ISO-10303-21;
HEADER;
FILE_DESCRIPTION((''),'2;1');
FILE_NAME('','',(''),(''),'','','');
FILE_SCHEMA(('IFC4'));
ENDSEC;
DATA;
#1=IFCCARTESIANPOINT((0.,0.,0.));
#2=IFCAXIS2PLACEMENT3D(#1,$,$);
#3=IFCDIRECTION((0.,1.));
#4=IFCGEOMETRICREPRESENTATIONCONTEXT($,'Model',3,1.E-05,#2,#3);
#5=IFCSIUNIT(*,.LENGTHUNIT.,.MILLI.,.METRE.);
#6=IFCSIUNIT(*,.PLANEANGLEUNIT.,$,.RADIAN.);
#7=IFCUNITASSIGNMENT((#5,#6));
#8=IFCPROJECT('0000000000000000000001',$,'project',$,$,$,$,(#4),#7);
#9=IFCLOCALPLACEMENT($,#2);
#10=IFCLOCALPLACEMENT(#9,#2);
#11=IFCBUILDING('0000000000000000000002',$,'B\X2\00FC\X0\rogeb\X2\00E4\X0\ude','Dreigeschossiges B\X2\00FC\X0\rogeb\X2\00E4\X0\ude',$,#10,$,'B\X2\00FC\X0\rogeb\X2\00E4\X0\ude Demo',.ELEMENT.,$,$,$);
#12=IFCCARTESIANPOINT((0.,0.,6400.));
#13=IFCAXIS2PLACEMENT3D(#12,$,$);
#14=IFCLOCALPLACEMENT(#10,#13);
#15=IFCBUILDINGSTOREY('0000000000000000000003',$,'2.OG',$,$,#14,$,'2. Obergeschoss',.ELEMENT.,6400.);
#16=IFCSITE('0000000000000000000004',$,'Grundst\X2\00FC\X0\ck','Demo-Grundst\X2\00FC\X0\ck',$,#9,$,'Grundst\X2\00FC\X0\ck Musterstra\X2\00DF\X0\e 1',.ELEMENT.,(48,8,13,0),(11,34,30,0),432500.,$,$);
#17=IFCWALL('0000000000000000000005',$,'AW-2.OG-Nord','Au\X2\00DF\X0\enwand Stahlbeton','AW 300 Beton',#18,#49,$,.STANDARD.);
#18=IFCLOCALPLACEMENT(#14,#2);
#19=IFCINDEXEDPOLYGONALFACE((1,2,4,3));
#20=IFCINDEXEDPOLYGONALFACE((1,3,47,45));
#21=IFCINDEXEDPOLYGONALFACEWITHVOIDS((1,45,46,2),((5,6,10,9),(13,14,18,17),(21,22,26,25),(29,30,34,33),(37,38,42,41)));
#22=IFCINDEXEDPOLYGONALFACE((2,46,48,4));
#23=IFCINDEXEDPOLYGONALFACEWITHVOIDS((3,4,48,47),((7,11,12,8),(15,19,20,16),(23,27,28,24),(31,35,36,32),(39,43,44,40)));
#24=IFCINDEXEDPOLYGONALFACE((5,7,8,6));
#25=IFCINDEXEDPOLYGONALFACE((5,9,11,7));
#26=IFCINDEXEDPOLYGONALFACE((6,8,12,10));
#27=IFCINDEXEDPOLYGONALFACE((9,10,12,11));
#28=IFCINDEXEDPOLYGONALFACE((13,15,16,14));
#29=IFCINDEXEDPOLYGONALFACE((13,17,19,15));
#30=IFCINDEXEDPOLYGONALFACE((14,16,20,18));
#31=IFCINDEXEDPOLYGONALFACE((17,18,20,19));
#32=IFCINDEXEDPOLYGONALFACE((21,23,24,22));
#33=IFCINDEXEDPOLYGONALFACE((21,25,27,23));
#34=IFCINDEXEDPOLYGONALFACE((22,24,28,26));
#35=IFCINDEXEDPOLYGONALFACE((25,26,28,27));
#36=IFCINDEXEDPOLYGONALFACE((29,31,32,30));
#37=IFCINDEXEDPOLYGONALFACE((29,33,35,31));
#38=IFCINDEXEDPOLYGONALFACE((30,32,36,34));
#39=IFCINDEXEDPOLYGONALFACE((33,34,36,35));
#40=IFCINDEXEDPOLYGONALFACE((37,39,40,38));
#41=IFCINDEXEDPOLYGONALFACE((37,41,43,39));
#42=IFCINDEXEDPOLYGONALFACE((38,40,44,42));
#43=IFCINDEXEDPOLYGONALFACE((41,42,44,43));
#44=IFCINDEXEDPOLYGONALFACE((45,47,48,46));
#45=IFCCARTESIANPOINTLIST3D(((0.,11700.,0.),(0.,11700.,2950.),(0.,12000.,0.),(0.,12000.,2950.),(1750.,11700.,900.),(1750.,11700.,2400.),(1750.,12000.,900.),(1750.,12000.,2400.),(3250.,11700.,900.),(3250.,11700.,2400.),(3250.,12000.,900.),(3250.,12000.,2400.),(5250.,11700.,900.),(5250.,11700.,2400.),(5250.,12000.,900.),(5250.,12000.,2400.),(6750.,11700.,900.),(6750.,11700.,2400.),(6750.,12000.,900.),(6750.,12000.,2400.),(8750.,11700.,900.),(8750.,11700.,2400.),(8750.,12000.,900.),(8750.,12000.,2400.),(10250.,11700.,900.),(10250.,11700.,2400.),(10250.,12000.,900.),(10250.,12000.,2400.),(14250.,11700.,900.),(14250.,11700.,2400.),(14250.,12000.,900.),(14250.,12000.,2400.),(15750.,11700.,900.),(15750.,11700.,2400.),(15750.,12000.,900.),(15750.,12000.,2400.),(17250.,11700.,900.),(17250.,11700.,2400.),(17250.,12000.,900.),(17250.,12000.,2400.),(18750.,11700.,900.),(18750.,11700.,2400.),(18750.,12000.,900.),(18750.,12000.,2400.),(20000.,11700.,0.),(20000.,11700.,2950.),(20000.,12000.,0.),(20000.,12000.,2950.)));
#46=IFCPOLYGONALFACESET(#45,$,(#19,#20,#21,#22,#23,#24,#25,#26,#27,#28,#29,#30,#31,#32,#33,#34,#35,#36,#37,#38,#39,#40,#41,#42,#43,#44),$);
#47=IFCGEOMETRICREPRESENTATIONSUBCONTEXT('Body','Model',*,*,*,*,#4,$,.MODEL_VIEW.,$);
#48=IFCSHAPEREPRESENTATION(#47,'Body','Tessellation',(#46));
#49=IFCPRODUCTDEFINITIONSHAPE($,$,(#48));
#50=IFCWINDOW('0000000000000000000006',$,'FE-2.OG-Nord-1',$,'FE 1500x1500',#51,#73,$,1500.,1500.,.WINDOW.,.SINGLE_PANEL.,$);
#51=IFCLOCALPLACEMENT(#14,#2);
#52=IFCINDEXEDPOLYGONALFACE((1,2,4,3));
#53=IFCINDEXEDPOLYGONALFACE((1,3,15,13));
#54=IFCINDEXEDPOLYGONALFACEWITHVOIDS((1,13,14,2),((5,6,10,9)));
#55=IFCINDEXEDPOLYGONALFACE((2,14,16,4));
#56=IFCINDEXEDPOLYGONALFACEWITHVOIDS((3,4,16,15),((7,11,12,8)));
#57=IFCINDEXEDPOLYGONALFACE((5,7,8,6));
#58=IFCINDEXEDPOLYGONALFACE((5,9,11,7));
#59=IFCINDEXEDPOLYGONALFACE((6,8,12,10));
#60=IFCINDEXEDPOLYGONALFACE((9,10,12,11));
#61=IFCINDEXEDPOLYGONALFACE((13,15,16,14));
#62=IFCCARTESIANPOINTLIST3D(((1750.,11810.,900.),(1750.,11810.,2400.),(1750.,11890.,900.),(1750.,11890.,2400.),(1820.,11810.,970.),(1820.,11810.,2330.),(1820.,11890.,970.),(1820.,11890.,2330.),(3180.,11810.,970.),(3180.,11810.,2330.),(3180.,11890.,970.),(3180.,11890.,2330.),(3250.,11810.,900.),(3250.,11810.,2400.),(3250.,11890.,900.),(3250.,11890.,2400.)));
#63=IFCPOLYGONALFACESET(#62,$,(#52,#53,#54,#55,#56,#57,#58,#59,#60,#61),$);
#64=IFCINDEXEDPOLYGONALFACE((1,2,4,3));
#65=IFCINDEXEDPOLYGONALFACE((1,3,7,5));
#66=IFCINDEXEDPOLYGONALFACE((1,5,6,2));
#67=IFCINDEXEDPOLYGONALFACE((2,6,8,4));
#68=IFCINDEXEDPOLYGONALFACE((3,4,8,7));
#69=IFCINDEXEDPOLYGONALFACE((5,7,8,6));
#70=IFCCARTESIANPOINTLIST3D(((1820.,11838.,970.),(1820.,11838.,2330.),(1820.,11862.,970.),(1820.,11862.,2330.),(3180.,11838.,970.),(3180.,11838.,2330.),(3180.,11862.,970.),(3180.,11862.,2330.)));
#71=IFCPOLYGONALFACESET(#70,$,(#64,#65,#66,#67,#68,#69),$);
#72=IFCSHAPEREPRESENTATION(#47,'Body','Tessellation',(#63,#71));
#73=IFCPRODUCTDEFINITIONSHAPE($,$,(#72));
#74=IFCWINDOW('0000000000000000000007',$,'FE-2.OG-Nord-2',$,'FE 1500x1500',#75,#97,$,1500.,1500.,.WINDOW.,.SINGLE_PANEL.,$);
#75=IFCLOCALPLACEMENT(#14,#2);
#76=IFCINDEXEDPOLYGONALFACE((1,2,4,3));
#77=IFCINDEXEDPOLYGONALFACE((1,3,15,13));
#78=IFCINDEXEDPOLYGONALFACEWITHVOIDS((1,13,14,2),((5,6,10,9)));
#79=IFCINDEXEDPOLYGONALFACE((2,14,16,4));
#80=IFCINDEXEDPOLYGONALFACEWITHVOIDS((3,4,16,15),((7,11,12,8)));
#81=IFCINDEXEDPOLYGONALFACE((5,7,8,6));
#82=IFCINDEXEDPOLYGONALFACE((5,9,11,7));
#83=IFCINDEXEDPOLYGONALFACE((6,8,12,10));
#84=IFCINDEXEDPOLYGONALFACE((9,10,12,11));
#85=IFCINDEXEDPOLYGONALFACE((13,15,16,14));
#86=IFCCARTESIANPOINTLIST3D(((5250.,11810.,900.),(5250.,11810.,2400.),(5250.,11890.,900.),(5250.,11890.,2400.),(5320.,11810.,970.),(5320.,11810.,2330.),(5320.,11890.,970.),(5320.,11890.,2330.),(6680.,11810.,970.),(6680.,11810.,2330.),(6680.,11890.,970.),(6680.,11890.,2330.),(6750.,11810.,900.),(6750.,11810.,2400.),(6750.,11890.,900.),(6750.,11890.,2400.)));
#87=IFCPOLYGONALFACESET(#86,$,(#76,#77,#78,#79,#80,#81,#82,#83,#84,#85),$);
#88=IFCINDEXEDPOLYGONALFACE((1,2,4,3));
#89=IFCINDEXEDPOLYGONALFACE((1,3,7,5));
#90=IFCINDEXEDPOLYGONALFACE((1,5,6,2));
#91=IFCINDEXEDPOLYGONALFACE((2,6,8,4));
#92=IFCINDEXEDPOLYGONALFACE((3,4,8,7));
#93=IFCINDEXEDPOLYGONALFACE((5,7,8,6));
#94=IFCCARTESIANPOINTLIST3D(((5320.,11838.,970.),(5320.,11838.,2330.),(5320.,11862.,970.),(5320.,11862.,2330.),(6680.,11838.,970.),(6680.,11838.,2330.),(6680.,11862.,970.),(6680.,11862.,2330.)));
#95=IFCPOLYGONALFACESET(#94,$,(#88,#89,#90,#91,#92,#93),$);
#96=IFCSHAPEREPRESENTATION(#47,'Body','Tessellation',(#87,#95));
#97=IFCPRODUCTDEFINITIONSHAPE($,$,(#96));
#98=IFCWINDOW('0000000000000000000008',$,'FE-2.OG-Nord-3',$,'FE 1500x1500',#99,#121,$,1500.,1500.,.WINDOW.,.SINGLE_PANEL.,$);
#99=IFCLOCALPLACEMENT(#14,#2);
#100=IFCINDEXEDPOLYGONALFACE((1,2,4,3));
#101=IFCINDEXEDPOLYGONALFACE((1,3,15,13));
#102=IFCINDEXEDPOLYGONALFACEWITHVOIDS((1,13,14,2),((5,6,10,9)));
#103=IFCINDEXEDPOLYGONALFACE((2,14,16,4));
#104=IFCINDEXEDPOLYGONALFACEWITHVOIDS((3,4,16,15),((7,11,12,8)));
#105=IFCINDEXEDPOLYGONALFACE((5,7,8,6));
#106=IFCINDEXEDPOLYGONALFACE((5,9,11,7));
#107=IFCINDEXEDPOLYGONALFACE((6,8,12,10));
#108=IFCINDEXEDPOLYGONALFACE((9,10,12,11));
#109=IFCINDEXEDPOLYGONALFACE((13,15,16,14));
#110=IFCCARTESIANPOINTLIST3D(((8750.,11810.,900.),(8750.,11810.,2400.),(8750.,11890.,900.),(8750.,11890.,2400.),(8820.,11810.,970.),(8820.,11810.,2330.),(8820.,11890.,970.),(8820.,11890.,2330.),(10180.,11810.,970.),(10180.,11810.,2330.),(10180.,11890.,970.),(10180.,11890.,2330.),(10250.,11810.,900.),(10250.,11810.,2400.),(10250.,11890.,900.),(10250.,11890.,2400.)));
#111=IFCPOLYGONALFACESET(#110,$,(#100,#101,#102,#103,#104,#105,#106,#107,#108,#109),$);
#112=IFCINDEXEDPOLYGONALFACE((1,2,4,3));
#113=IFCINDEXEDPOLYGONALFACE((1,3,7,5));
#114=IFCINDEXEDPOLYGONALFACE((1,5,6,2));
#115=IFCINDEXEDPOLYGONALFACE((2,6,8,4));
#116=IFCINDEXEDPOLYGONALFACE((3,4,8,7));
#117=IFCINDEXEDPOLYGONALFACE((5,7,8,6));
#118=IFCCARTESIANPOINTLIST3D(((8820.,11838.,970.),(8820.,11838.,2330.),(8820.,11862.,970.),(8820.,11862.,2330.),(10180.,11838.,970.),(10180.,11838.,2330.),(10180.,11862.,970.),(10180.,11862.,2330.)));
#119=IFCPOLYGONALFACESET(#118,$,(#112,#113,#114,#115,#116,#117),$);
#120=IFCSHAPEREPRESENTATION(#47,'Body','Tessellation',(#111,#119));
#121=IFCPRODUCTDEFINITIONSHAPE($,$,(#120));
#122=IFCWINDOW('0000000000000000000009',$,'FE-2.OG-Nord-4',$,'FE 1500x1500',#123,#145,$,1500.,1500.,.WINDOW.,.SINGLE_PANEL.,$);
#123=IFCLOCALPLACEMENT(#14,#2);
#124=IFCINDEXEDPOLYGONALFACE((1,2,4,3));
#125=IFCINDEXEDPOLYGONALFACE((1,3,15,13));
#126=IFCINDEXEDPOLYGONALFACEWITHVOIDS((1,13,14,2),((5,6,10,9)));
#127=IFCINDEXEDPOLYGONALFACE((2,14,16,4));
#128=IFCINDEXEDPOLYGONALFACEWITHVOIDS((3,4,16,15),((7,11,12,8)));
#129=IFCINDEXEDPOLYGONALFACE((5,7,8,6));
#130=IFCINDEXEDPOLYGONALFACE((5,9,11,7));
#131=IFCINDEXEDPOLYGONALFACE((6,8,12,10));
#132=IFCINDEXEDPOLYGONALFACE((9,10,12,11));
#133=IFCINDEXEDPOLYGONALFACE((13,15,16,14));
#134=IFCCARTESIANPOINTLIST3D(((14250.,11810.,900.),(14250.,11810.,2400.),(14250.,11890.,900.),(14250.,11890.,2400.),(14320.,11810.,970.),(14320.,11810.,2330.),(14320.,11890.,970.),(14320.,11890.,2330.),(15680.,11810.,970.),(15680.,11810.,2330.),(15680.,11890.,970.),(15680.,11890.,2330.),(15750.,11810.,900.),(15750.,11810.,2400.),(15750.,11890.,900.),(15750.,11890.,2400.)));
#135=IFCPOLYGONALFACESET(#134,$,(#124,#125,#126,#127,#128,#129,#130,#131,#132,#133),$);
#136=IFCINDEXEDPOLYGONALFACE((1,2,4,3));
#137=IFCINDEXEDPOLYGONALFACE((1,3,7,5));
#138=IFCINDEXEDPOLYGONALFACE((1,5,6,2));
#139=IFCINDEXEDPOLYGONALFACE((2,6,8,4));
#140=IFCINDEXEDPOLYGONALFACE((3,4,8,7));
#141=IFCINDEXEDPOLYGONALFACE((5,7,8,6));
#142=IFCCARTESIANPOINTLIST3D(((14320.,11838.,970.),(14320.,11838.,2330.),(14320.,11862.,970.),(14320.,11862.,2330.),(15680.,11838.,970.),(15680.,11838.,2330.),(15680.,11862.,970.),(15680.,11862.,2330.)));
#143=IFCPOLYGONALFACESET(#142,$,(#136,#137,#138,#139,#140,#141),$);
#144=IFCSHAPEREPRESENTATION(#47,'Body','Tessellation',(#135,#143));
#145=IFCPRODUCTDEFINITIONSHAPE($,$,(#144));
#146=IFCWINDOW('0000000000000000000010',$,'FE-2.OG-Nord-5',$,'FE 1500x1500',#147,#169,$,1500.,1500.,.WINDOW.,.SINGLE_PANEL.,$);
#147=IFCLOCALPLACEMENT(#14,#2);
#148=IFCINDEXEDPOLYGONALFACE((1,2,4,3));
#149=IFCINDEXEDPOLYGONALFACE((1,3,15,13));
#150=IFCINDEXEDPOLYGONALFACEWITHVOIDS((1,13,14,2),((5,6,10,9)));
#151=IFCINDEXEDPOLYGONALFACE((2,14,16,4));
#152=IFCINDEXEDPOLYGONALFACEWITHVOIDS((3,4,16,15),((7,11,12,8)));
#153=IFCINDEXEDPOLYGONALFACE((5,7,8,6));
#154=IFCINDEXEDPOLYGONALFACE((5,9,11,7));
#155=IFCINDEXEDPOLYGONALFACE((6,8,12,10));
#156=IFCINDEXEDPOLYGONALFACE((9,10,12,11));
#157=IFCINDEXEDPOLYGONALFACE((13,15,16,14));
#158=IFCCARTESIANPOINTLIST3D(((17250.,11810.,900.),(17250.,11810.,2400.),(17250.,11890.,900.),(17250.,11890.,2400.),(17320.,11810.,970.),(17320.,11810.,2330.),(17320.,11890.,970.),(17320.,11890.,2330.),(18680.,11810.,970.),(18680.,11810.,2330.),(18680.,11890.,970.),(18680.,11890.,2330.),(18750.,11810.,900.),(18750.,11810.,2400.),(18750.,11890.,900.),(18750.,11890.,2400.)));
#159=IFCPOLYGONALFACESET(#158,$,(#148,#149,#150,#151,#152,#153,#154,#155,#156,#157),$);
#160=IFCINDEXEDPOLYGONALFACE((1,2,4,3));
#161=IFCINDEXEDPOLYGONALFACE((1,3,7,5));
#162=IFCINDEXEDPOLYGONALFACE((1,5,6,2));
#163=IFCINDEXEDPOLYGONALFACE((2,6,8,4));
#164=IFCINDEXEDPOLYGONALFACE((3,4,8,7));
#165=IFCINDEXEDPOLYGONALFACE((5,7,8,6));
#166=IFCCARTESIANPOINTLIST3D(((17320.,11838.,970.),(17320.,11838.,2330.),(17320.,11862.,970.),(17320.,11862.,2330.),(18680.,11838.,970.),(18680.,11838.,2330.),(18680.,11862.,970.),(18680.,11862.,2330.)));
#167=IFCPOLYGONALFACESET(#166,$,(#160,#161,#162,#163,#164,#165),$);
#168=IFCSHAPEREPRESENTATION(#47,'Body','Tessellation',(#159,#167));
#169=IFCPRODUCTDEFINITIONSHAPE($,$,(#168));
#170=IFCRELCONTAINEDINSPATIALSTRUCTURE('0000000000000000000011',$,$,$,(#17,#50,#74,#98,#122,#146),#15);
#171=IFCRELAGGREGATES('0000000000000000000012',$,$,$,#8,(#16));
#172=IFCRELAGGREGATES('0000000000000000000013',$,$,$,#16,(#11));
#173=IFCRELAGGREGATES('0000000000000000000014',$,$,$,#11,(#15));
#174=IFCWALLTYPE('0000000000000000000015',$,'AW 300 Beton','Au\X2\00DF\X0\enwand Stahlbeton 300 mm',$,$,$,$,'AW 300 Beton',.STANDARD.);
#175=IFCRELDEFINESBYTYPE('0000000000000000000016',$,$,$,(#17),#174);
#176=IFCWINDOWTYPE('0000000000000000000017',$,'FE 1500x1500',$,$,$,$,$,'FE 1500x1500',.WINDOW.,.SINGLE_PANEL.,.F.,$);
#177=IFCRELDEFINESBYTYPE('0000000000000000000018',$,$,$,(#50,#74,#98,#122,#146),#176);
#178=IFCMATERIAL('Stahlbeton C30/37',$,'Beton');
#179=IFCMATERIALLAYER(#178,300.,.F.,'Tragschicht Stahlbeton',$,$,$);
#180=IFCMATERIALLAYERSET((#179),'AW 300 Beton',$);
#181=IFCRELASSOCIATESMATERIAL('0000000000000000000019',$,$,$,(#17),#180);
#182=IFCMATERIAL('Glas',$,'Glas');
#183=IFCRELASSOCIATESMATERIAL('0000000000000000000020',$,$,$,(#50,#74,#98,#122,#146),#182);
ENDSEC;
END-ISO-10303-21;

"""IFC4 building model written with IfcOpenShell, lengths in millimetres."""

from ifc_helpers import new_model, si_unit, direction, frame, frame_2d, origin, origin_2d, place, context, subcontext, project, spatial, polyline, rectangle, outline, extrude, material, layer, layer_set, layer_usage, type_object, element, fill, save


model = new_model("IFC4")

# Units and contexts
model_context = context("Model", 3, precision=1e-05, world=origin(), true_north=direction((0.0, 1.0)))
body_context = subcontext(model_context, "Body", "Model", "MODEL_VIEW")
ifc_project = project(units=[si_unit("LENGTHUNIT", "METRE", prefix="MILLI"), si_unit("PLANEANGLEUNIT", "RADIAN")], contexts=[model_context])

# Site, building, storey
site_placement = place(None, origin())
site = spatial("IfcSite", under=ifc_project, at=site_placement, Name="Grundstück", Description="Demo-Grundstück", LongName="Grundstück Musterstraße 1", CompositionType="ELEMENT", RefLatitude=(48, 8, 13, 0), RefLongitude=(11, 34, 30, 0), RefElevation=432500.0)
building_placement = place(site_placement, origin())
building = spatial("IfcBuilding", under=site, at=building_placement, Name="Bürogebäude", Description="Dreigeschossiges Bürogebäude", LongName="Bürogebäude Demo", CompositionType="ELEMENT")
storey_placement = place(building_placement, frame((0.0, 0.0, 6400.0)))
storey = spatial("IfcBuildingStorey", under=building, at=storey_placement, Name="2.OG", LongName="2. Obergeschoss", CompositionType="ELEMENT", Elevation=6400.0)

# Shared definitions
ifc_material_1 = material(Name="Stahlbeton C30/37", Category="Beton")

# Wall, openings, windows
ifc_layer_1 = layer(ifc_material_1, 300.0, ventilated=False, Name="Tragschicht Stahlbeton")
ifc_layer_set_1 = layer_set([ifc_layer_1], Name="AW 300 Beton")
ifc_layer_usage_1 = layer_usage(ifc_layer_set_1, "AXIS2", "POSITIVE", -150.0)
wall_type_1 = type_object("IfcWallType", Name="AW 300 Beton", Description="Außenwand Stahlbeton 300 mm", ElementType="AW 300 Beton", PredefinedType="STANDARD")
wall_1_placement = place(storey_placement, frame((0.0, 11850.0, 0.0)))
wall_1 = element("IfcWall", 1, at=wall_1_placement, inside=storey, type_object=wall_type_1, material=ifc_layer_usage_1, Name="AW-2.OG-Nord", Description="Außenwand Stahlbeton", ObjectType="AW 300 Beton", PredefinedType="STANDARD", context=body_context, shape_type="SweptSolid", body=[
    extrude(rectangle(XDim=20000.0, YDim=300.0, at=frame_2d((10000.0, 0.0))), origin(), (0.0, 0.0, 1.0), 2950.0),
])
opening_1_placement = place(wall_1_placement, frame((2500.0, 0.0, 900.0)))
opening_1 = element("IfcOpeningElement", 2, at=opening_1_placement, cuts=wall_1, PredefinedType="OPENING", context=body_context, shape_type="SweptSolid", body=[
    extrude(rectangle(XDim=1500.0, YDim=340.0, at=origin_2d()), origin(), (0.0, 0.0, 1.0), 1500.0),
])
opening_2_placement = place(wall_1_placement, frame((6000.0, 0.0, 900.0)))
opening_2 = element("IfcOpeningElement", 3, at=opening_2_placement, cuts=wall_1, PredefinedType="OPENING", context=body_context, shape_type="SweptSolid", body=[
    extrude(rectangle(XDim=1500.0, YDim=340.0, at=origin_2d()), origin(), (0.0, 0.0, 1.0), 1500.0),
])
opening_3_placement = place(wall_1_placement, frame((9500.0, 0.0, 900.0)))
opening_3 = element("IfcOpeningElement", 4, at=opening_3_placement, cuts=wall_1, PredefinedType="OPENING", context=body_context, shape_type="SweptSolid", body=[
    extrude(rectangle(XDim=1500.0, YDim=340.0, at=origin_2d()), origin(), (0.0, 0.0, 1.0), 1500.0),
])
opening_4_placement = place(wall_1_placement, frame((15000.0, 0.0, 900.0)))
opening_4 = element("IfcOpeningElement", 5, at=opening_4_placement, cuts=wall_1, PredefinedType="OPENING", context=body_context, shape_type="SweptSolid", body=[
    extrude(rectangle(XDim=1500.0, YDim=340.0, at=origin_2d()), origin(), (0.0, 0.0, 1.0), 1500.0),
])
opening_5_placement = place(wall_1_placement, frame((18000.0, 0.0, 900.0)))
opening_5 = element("IfcOpeningElement", 6, at=opening_5_placement, cuts=wall_1, PredefinedType="OPENING", context=body_context, shape_type="SweptSolid", body=[
    extrude(rectangle(XDim=1500.0, YDim=340.0, at=origin_2d()), origin(), (0.0, 0.0, 1.0), 1500.0),
])
ifc_material_2 = material(Name="Glas", Category="Glas")
window_type = type_object("IfcWindowType", Name="FE 1500x1500", ElementType="FE 1500x1500", ParameterTakesPrecedence=False, PartitioningType="SINGLE_PANEL", PredefinedType="WINDOW")
window_1_placement = place(opening_1_placement, origin())
window_1 = element("IfcWindow", 7, at=window_1_placement, inside=storey, type_object=window_type, material=ifc_material_2, Name="FE-2.OG-Nord-1", ObjectType="FE 1500x1500", OverallHeight=1500.0, OverallWidth=1500.0, PartitioningType="SINGLE_PANEL", PredefinedType="WINDOW", context=body_context, shape_type="SweptSolid", body=[
    extrude(outline(polyline([(-750.0, 0.0), (750.0, 0.0), (750.0, 1500.0), (-750.0, 1500.0), (-750.0, 0.0)]), holes=[polyline([(-680.0, 70.0), (680.0, 70.0), (680.0, 1430.0), (-680.0, 1430.0), (-680.0, 70.0)])]), frame((0.0, 40.0, 0.0), z_axis=(0.0, -1.0, 0.0), x_axis=(1.0, 0.0, 0.0)), (0.0, 0.0, 1.0), 80.0),
    extrude(rectangle(XDim=1360.0, YDim=24.0, at=origin_2d()), frame((0.0, 0.0, 70.0)), (0.0, 0.0, 1.0), 1360.0),
])
fill(opening_1, window_1)
window_2_placement = place(opening_2_placement, origin())
window_2 = element("IfcWindow", 8, at=window_2_placement, inside=storey, type_object=window_type, material=ifc_material_2, Name="FE-2.OG-Nord-2", ObjectType="FE 1500x1500", OverallHeight=1500.0, OverallWidth=1500.0, PartitioningType="SINGLE_PANEL", PredefinedType="WINDOW", context=body_context, shape_type="SweptSolid", body=[
    extrude(outline(polyline([(-750.0, 0.0), (750.0, 0.0), (750.0, 1500.0), (-750.0, 1500.0), (-750.0, 0.0)]), holes=[polyline([(-680.0, 70.0), (680.0, 70.0), (680.0, 1430.0), (-680.0, 1430.0), (-680.0, 70.0)])]), frame((0.0, 40.0, 0.0), z_axis=(0.0, -1.0, 0.0), x_axis=(1.0, 0.0, 0.0)), (0.0, 0.0, 1.0), 80.0),
    extrude(rectangle(XDim=1360.0, YDim=24.0, at=origin_2d()), frame((0.0, 0.0, 70.0)), (0.0, 0.0, 1.0), 1360.0),
])
fill(opening_2, window_2)
window_3_placement = place(opening_3_placement, origin())
window_3 = element("IfcWindow", 9, at=window_3_placement, inside=storey, type_object=window_type, material=ifc_material_2, Name="FE-2.OG-Nord-3", ObjectType="FE 1500x1500", OverallHeight=1500.0, OverallWidth=1500.0, PartitioningType="SINGLE_PANEL", PredefinedType="WINDOW", context=body_context, shape_type="SweptSolid", body=[
    extrude(outline(polyline([(-750.0, 0.0), (750.0, 0.0), (750.0, 1500.0), (-750.0, 1500.0), (-750.0, 0.0)]), holes=[polyline([(-680.0, 70.0), (680.0, 70.0), (680.0, 1430.0), (-680.0, 1430.0), (-680.0, 70.0)])]), frame((0.0, 40.0, 0.0), z_axis=(0.0, -1.0, 0.0), x_axis=(1.0, 0.0, 0.0)), (0.0, 0.0, 1.0), 80.0),
    extrude(rectangle(XDim=1360.0, YDim=24.0, at=origin_2d()), frame((0.0, 0.0, 70.0)), (0.0, 0.0, 1.0), 1360.0),
])
fill(opening_3, window_3)
window_4_placement = place(opening_4_placement, origin())
window_4 = element("IfcWindow", 10, at=window_4_placement, inside=storey, type_object=window_type, material=ifc_material_2, Name="FE-2.OG-Nord-4", ObjectType="FE 1500x1500", OverallHeight=1500.0, OverallWidth=1500.0, PartitioningType="SINGLE_PANEL", PredefinedType="WINDOW", context=body_context, shape_type="SweptSolid", body=[
    extrude(outline(polyline([(-750.0, 0.0), (750.0, 0.0), (750.0, 1500.0), (-750.0, 1500.0), (-750.0, 0.0)]), holes=[polyline([(-680.0, 70.0), (680.0, 70.0), (680.0, 1430.0), (-680.0, 1430.0), (-680.0, 70.0)])]), frame((0.0, 40.0, 0.0), z_axis=(0.0, -1.0, 0.0), x_axis=(1.0, 0.0, 0.0)), (0.0, 0.0, 1.0), 80.0),
    extrude(rectangle(XDim=1360.0, YDim=24.0, at=origin_2d()), frame((0.0, 0.0, 70.0)), (0.0, 0.0, 1.0), 1360.0),
])
fill(opening_4, window_4)
window_5_placement = place(opening_5_placement, origin())
window_5 = element("IfcWindow", 11, at=window_5_placement, inside=storey, type_object=window_type, material=ifc_material_2, Name="FE-2.OG-Nord-5", ObjectType="FE 1500x1500", OverallHeight=1500.0, OverallWidth=1500.0, PartitioningType="SINGLE_PANEL", PredefinedType="WINDOW", context=body_context, shape_type="SweptSolid", body=[
    extrude(outline(polyline([(-750.0, 0.0), (750.0, 0.0), (750.0, 1500.0), (-750.0, 1500.0), (-750.0, 0.0)]), holes=[polyline([(-680.0, 70.0), (680.0, 70.0), (680.0, 1430.0), (-680.0, 1430.0), (-680.0, 70.0)])]), frame((0.0, 40.0, 0.0), z_axis=(0.0, -1.0, 0.0), x_axis=(1.0, 0.0, 0.0)), (0.0, 0.0, 1.0), 80.0),
    extrude(rectangle(XDim=1360.0, YDim=24.0, at=origin_2d()), frame((0.0, 0.0, 70.0)), (0.0, 0.0, 1.0), 1360.0),
])
fill(opening_5, window_5)

save(model, "model.ifc")
